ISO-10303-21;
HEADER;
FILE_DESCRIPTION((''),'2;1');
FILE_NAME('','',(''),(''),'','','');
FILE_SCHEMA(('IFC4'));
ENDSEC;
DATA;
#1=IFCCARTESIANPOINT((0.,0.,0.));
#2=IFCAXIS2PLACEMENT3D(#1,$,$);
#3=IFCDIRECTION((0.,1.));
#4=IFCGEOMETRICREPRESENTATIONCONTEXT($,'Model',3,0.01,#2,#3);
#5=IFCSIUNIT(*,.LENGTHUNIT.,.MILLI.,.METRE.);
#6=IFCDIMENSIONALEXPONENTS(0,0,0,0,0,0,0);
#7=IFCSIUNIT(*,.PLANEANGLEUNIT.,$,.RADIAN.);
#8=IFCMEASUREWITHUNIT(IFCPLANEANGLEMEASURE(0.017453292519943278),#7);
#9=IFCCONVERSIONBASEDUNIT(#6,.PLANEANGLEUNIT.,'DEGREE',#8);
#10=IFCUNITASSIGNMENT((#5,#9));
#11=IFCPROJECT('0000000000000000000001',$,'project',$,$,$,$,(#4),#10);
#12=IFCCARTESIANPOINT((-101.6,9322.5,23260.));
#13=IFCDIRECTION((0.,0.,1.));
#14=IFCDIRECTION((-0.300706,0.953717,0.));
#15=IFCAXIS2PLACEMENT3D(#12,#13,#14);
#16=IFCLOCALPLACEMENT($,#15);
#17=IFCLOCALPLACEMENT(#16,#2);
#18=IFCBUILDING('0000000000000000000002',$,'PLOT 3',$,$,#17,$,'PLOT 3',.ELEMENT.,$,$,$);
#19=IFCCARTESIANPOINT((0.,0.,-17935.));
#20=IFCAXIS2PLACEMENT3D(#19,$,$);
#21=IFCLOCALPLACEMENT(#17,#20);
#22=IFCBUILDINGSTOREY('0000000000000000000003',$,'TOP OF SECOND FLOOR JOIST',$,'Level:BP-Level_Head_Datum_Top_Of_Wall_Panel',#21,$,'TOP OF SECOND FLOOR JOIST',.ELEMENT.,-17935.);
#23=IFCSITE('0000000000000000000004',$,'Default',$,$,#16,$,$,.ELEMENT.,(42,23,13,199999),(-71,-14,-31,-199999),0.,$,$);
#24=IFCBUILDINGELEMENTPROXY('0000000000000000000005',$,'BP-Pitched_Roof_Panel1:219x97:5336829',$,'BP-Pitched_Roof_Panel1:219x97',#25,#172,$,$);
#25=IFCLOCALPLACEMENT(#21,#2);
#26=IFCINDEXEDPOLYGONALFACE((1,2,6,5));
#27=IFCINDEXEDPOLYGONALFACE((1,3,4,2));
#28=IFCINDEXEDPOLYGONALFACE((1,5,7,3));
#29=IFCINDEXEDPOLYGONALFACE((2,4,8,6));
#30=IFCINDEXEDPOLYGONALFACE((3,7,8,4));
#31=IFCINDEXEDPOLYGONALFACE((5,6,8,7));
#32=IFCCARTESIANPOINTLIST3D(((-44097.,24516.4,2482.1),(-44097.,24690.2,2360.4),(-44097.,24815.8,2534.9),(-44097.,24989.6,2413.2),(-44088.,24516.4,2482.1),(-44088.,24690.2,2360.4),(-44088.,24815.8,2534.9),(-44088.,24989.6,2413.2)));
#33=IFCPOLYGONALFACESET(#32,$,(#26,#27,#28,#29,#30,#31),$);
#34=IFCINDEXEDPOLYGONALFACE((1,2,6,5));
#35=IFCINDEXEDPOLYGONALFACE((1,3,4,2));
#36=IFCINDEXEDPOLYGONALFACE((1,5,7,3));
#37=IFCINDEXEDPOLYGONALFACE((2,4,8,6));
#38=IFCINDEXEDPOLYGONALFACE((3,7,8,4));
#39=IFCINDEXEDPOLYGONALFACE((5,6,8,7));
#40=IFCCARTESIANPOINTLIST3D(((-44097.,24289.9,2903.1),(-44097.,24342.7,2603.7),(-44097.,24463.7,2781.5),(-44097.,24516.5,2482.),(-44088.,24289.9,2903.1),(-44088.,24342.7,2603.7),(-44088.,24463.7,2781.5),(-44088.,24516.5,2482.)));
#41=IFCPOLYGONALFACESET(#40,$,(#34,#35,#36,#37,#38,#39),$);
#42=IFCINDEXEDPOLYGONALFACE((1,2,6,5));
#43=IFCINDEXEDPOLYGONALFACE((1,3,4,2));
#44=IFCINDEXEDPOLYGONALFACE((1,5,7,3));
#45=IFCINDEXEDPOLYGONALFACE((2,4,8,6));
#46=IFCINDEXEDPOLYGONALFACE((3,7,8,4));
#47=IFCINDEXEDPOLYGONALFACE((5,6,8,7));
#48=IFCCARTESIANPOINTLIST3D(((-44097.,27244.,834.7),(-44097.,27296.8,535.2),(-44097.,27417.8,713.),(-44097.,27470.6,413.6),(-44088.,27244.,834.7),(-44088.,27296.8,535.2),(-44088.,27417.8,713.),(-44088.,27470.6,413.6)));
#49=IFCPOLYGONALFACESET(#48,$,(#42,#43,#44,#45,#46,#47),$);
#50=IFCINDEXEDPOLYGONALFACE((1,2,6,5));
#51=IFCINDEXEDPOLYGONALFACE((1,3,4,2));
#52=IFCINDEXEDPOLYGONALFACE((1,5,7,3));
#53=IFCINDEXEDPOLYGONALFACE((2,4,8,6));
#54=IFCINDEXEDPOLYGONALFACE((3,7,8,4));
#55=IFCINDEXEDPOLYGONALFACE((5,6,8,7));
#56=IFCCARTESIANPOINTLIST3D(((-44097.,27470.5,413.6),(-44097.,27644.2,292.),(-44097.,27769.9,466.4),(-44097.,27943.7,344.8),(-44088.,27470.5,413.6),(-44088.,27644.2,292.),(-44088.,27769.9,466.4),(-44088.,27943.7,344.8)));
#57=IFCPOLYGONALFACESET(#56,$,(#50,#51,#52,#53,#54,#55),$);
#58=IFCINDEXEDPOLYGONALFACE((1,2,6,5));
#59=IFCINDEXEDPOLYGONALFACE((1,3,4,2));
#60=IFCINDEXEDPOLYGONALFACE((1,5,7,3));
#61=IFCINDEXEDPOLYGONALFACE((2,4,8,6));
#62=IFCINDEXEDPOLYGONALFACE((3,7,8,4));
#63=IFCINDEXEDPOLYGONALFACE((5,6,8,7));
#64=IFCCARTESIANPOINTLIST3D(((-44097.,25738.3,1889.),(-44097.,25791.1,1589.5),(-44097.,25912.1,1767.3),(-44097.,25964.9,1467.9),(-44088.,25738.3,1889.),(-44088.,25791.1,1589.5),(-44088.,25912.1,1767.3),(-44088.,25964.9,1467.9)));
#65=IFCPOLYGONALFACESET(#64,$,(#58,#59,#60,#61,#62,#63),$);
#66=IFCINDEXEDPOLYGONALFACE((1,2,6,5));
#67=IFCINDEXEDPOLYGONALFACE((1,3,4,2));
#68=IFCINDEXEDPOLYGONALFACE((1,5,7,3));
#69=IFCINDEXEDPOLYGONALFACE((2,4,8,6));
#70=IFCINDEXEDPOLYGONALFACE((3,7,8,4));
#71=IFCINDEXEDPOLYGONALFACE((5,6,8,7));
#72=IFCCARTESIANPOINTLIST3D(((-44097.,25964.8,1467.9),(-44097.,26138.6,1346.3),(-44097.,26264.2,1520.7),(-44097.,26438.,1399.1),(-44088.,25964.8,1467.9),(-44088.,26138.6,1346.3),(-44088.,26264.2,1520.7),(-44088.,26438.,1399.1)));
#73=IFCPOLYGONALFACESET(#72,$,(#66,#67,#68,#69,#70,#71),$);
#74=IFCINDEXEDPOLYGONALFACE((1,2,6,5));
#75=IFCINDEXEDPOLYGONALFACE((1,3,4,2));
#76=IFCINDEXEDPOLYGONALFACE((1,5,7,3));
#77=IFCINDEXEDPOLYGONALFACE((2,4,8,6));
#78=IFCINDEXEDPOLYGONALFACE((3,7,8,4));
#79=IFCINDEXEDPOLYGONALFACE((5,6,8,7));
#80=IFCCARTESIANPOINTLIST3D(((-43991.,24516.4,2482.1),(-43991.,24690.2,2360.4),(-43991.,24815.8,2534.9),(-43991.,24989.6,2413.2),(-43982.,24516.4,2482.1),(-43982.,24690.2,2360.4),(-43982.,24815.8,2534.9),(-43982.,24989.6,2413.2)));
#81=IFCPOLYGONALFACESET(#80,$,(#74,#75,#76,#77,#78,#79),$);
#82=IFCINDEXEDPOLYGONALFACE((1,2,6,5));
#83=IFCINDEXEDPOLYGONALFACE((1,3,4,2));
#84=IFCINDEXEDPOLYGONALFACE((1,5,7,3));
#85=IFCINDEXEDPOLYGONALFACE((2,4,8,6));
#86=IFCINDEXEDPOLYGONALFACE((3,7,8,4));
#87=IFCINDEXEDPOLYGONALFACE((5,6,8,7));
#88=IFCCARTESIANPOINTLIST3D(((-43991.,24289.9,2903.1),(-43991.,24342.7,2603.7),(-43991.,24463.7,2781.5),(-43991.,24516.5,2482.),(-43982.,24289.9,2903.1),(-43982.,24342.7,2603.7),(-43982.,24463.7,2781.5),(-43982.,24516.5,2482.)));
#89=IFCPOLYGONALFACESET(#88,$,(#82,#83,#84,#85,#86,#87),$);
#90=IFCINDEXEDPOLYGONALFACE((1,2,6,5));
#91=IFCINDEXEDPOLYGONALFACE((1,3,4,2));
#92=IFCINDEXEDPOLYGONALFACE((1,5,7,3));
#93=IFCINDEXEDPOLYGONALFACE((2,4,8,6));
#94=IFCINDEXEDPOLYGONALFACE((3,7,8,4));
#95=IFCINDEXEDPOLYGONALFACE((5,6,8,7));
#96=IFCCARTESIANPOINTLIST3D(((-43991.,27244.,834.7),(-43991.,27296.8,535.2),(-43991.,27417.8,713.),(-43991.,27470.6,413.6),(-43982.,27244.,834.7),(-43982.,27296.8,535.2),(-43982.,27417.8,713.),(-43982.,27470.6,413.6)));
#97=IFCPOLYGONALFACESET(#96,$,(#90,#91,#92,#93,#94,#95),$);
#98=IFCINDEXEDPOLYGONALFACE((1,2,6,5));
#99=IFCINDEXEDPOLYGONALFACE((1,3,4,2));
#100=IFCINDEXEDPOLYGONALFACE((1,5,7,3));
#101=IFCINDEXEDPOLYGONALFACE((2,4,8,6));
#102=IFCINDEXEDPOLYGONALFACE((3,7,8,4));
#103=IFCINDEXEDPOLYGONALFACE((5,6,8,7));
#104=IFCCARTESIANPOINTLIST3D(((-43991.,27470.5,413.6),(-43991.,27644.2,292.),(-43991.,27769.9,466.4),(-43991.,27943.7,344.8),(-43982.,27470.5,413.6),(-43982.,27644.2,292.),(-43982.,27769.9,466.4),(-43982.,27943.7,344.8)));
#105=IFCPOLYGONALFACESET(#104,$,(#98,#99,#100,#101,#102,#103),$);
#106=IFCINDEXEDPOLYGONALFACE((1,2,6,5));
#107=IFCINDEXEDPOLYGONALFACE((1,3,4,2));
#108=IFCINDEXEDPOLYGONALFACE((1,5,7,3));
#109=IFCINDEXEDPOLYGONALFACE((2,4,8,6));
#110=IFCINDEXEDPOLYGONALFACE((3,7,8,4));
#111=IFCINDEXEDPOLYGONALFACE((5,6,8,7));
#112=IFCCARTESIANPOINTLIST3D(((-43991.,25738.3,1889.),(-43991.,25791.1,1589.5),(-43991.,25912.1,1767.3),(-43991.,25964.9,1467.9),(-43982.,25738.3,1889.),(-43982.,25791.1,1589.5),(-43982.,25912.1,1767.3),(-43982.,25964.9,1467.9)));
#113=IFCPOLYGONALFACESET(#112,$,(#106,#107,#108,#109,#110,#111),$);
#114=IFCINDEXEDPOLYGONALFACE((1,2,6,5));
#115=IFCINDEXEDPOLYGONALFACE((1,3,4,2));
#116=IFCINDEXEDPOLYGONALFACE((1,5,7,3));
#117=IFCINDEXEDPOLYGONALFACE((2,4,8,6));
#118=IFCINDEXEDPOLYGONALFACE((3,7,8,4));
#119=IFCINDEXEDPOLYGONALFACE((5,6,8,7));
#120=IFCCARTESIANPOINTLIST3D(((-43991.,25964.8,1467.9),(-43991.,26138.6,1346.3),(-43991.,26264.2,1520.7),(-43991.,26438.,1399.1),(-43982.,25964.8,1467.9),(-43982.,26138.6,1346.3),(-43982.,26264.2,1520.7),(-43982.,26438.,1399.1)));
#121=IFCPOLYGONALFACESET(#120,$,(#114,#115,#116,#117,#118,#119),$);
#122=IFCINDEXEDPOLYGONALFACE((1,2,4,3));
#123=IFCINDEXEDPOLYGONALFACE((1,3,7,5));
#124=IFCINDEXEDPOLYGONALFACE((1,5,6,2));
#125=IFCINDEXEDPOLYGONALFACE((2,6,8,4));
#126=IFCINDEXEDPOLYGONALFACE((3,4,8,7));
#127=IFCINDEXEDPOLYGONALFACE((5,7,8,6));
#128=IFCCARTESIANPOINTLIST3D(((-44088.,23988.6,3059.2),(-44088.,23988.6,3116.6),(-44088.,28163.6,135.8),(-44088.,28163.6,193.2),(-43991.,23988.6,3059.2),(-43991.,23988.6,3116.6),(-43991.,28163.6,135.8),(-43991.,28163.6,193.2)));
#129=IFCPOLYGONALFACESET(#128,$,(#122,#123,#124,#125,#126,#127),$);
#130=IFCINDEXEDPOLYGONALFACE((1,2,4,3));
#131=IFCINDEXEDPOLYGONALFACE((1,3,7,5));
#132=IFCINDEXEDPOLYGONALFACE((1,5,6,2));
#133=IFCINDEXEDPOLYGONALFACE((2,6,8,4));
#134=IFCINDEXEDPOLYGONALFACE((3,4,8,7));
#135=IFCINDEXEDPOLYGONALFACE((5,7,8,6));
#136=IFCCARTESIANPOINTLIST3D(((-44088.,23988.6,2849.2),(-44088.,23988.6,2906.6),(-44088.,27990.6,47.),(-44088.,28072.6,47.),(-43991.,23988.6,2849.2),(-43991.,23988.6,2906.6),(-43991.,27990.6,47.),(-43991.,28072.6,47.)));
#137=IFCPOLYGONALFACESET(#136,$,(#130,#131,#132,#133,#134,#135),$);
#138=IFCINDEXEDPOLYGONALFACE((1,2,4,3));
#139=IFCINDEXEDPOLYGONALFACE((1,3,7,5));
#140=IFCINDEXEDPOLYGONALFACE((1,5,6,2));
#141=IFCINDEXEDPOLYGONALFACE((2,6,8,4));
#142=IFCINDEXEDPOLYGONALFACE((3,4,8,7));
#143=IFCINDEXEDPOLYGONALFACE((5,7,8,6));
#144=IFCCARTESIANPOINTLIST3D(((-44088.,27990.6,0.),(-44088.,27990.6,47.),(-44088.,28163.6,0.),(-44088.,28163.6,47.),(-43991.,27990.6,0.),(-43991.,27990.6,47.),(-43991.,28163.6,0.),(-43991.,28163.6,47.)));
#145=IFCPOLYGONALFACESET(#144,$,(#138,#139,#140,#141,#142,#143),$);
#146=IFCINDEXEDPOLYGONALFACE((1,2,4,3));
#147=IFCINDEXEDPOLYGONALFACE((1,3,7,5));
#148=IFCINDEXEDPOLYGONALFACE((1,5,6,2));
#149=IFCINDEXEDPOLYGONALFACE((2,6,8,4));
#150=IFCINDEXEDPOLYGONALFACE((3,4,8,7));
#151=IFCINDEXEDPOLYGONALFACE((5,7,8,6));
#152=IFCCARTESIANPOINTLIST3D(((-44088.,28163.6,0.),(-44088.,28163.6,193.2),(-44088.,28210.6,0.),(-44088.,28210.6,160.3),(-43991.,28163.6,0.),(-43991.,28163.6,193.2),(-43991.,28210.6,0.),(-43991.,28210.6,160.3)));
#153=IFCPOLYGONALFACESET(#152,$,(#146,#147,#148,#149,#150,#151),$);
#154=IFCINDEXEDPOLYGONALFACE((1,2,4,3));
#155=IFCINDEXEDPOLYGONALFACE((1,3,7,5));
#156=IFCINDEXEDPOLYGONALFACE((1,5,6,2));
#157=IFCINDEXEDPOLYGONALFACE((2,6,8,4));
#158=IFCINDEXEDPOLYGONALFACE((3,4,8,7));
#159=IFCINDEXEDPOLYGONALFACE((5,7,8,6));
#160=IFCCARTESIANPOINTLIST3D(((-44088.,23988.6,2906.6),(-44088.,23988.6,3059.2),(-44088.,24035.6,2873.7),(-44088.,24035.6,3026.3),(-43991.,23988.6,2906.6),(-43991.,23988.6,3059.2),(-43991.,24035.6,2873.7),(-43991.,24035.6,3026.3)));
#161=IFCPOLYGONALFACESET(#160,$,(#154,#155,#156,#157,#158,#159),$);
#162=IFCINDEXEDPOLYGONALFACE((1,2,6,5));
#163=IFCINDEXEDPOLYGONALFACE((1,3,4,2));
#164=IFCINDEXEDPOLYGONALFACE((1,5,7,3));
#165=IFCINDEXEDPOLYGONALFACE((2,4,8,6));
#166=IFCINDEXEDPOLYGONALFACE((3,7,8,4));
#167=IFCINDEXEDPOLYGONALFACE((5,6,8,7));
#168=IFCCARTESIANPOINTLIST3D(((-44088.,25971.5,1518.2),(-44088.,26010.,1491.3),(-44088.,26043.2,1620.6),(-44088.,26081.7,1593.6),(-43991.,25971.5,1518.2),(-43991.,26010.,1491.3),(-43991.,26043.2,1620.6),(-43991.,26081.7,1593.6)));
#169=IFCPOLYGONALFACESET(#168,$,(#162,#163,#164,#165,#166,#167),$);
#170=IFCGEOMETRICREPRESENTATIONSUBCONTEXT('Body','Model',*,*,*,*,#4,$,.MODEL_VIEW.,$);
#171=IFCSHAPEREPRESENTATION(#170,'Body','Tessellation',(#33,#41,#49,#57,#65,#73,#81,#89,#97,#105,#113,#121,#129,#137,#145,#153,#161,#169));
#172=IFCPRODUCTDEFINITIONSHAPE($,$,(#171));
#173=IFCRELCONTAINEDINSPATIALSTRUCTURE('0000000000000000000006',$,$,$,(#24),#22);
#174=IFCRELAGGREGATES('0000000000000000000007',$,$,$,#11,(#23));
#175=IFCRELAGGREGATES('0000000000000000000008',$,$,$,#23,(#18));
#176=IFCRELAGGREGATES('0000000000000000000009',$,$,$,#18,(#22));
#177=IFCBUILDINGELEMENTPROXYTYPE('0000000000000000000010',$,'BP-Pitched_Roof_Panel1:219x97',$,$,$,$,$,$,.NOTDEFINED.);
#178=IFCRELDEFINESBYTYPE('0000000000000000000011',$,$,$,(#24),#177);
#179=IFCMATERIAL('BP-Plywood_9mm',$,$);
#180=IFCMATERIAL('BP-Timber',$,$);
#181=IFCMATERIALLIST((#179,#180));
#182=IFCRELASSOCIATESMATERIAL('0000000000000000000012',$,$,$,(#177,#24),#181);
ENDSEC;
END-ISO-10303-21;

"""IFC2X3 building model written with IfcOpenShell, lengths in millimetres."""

from ifc_helpers import new_model, entity, si_unit, converted_unit, direction, frame, frame_2d, origin, origin_2d_with_axis, place, context, subcontext, project, spatial, polyline, rectangle, outline, extrude, source, transform, mapped, material, material_list, type_object, type_shapes, element, save


model = new_model("IFC2X3")

# Units and contexts
model_context = context("Model", 3, precision=0.01, world=origin(), true_north=direction((0.0, 1.0)))
body_context = subcontext(model_context, "Body", "Model", "MODEL_VIEW")
ifc_project = project(units=[si_unit("LENGTHUNIT", "METRE", prefix="MILLI"), converted_unit("PLANEANGLEUNIT", "DEGREE", entity("IfcPlaneAngleMeasure", 0.017453292519943278), si_unit("PLANEANGLEUNIT", "RADIAN"), dimensions=[0, 0, 0, 0, 0, 0, 0])], contexts=[model_context])

# Site, building, storey
site_placement = place(None, frame((-101.6, 9322.5, 23260.0), z_axis=(0.0, 0.0, 1.0), x_axis=(-0.300706, 0.953717, 0.0)))
site = spatial("IfcSite", under=ifc_project, at=site_placement, Name="Default", CompositionType="ELEMENT", RefLatitude=(42, 23, 13, 199999), RefLongitude=(-71, -14, -31, -199999), RefElevation=0.0)
building_placement = place(site_placement, origin())
building = spatial("IfcBuilding", under=site, at=building_placement, Name="PLOT 3", LongName="PLOT 3", CompositionType="ELEMENT")
storey_placement = place(building_placement, frame((0.0, 0.0, -17935.0)))
storey = spatial("IfcBuildingStorey", under=building, at=storey_placement, Name="TOP OF SECOND FLOOR JOIST", ObjectType="Level:BP-Level_Head_Datum_Top_Of_Wall_Panel", LongName="TOP OF SECOND FLOOR JOIST", CompositionType="ELEMENT", Elevation=-17935.0)

# Building element proxy
ifc_material_1 = material(Name="BP-Timber")
ifc_material_2 = material(Name="BP-Plywood_9mm")
ifc_material_list = material_list([ifc_material_2, ifc_material_1])
building_element_proxy_type_1 = type_object("IfcBuildingElementProxyType", Name="BP-Pitched_Roof_Panel1:219x97", PredefinedType="NOTDEFINED", material=ifc_material_list)
shared_shape_1 = source(origin(), body_context, "Body", "SweptSolid", [
    extrude(outline(polyline([(-77.0, -75.0), (227.0, -75.0), (77.0, 75.0), (-227.0, 75.0), (-77.0, -75.0)])), frame((35.3, -3956.0, 2447.7), z_axis=(0.0, 1.0, 0.0), x_axis=(-0.984808, 0.0, 0.173648)), (0.0, 0.0, 1.0), 9.0),
    extrude(outline(polyline([(1.4, -107.5), (213.6, -107.5), (-1.4, 107.5), (-213.6, 107.5), (1.4, -107.5)])), frame((385.1, -3956.0, 2692.6), z_axis=(0.0, 1.0, 0.0), x_axis=(-0.819152, 0.0, -0.573576)), (0.0, 0.0, 1.0), 9.0),
    extrude(outline(polyline([(1.4, -107.5), (213.6, -107.5), (-1.4, 107.5), (-213.6, 107.5), (1.4, -107.5)])), frame((-2569.0, -3956.0, 624.1), z_axis=(0.0, 1.0, 0.0), x_axis=(-0.819152, 0.0, -0.573576)), (0.0, 0.0, 1.0), 9.0),
    extrude(outline(polyline([(-77.0, -75.0), (227.0, -75.0), (77.0, 75.0), (-227.0, 75.0), (-77.0, -75.0)])), frame((-2918.8, -3956.0, 379.2), z_axis=(0.0, 1.0, 0.0), x_axis=(-0.984808, 0.0, 0.173648)), (0.0, 0.0, 1.0), 9.0),
    extrude(outline(polyline([(1.4, -107.5), (213.6, -107.5), (-1.4, 107.5), (-213.6, 107.5), (1.4, -107.5)])), frame((-1063.3, -3956.0, 1678.4), z_axis=(0.0, 1.0, 0.0), x_axis=(-0.819152, 0.0, -0.573576)), (0.0, 0.0, 1.0), 9.0),
    extrude(outline(polyline([(-77.0, -75.0), (227.0, -75.0), (77.0, 75.0), (-227.0, 75.0), (-77.0, -75.0)])), frame((-1413.1, -3956.0, 1433.5), z_axis=(0.0, 1.0, 0.0), x_axis=(-0.984808, 0.0, 0.173648)), (0.0, 0.0, 1.0), 9.0),
    extrude(outline(polyline([(-77.0, -75.0), (227.0, -75.0), (77.0, 75.0), (-227.0, 75.0), (-77.0, -75.0)])), frame((35.3, -3850.0, 2447.7), z_axis=(0.0, 1.0, 0.0), x_axis=(-0.984808, 0.0, 0.173648)), (0.0, 0.0, 1.0), 9.0),
    extrude(outline(polyline([(1.4, -107.5), (213.6, -107.5), (-1.4, 107.5), (-213.6, 107.5), (1.4, -107.5)])), frame((385.1, -3850.0, 2692.6), z_axis=(0.0, 1.0, 0.0), x_axis=(-0.819152, 0.0, -0.573576)), (0.0, 0.0, 1.0), 9.0),
    extrude(outline(polyline([(1.4, -107.5), (213.6, -107.5), (-1.4, 107.5), (-213.6, 107.5), (1.4, -107.5)])), frame((-2569.0, -3850.0, 624.1), z_axis=(0.0, 1.0, 0.0), x_axis=(-0.819152, 0.0, -0.573576)), (0.0, 0.0, 1.0), 9.0),
    extrude(outline(polyline([(-77.0, -75.0), (227.0, -75.0), (77.0, 75.0), (-227.0, 75.0), (-77.0, -75.0)])), frame((-2918.8, -3850.0, 379.2), z_axis=(0.0, 1.0, 0.0), x_axis=(-0.984808, 0.0, 0.173648)), (0.0, 0.0, 1.0), 9.0),
    extrude(outline(polyline([(1.4, -107.5), (213.6, -107.5), (-1.4, 107.5), (-213.6, 107.5), (1.4, -107.5)])), frame((-1063.3, -3850.0, 1678.4), z_axis=(0.0, 1.0, 0.0), x_axis=(-0.819152, 0.0, -0.573576)), (0.0, 0.0, 1.0), 9.0),
    extrude(outline(polyline([(-77.0, -75.0), (227.0, -75.0), (77.0, 75.0), (-227.0, 75.0), (-77.0, -75.0)])), frame((-1413.1, -3850.0, 1433.5), z_axis=(0.0, 1.0, 0.0), x_axis=(-0.984808, 0.0, 0.173648)), (0.0, 0.0, 1.0), 9.0),
    extrude(outline(polyline([(-1490.4, -2087.5), (-1433.0, -2087.5), (1490.4, 2087.5), (1433.0, 2087.5), (-1490.4, -2087.5)])), frame((-1287.8, -3947.0, 1626.2), z_axis=(0.0, 1.0, 0.0), x_axis=(0.0, 0.0, -1.0)), (0.0, 0.0, 1.0), 97.0),
    extrude(outline(polyline([(-1444.1, -2021.5), (-1386.8, -2021.5), (1415.5, 1980.5), (1415.5, 2062.5), (-1444.1, -2021.5)])), frame((-1221.8, -3947.0, 1462.5), z_axis=(0.0, 1.0, 0.0), x_axis=(0.0, 0.0, -1.0)), (0.0, 0.0, 1.0), 97.0),
    extrude(rectangle(XDim=173.0, YDim=97.0, at=origin_2d_with_axis()), frame((-3288.8, -3898.5, 0.0), z_axis=(0.0, 0.0, 1.0), x_axis=(-1.0, 0.0, 0.0)), (0.0, 0.0, 1.0), 47.0),
    extrude(outline(polyline([(22.0, -72.4), (79.4, -72.4), (-31.4, 85.9), (-69.9, 58.9), (22.0, -72.4)])), frame((-3398.8, -3947.0, 88.4), z_axis=(0.0, 1.0, 0.0), x_axis=(0.819152, 0.0, 0.573576)), (0.0, 0.0, 1.0), 97.0),
    extrude(outline(polyline([(15.1, -62.5), (72.5, -62.5), (-15.1, 62.5), (-72.5, 62.5), (15.1, -62.5)])), frame((776.2, -3947.0, 2966.5), z_axis=(0.0, 1.0, 0.0), x_axis=(0.819152, 0.0, 0.573576)), (0.0, 0.0, 1.0), 97.0),
    extrude(rectangle(XDim=47.0, YDim=97.0, at=frame_2d((0.0, 0.0), x_axis=(1.0, 0.0))), frame((-1202.4, -3898.5, 1504.7), z_axis=(-0.573576, 0.0, 0.819152), x_axis=(-0.819152, 0.0, -0.573576)), (0.0, 0.0, 1.0), 125.0),
])
type_shapes(building_element_proxy_type_1, [shared_shape_1])
for number, where, z_axis, x_axis, name in (
    (1, (-40141.0, 24788.3, 0.0), (0.0, 0.0, 1.0), (0.0, -1.0, 0.0), "BP-Pitched_Roof_Panel1:219x97:5336829"),
):
    element("IfcBuildingElementProxy", number, at=place(storey_placement, frame(where, z_axis=z_axis, x_axis=x_axis)), inside=storey, type_object=building_element_proxy_type_1, material=ifc_material_list, Name=name, ObjectType="BP-Pitched_Roof_Panel1:219x97", context=body_context, shape_type="MappedRepresentation", body=[
        mapped(shared_shape_1, transform((0.0, 0.0, 0.0), scale=1.0)),
    ])

save(model, "model.ifc")
